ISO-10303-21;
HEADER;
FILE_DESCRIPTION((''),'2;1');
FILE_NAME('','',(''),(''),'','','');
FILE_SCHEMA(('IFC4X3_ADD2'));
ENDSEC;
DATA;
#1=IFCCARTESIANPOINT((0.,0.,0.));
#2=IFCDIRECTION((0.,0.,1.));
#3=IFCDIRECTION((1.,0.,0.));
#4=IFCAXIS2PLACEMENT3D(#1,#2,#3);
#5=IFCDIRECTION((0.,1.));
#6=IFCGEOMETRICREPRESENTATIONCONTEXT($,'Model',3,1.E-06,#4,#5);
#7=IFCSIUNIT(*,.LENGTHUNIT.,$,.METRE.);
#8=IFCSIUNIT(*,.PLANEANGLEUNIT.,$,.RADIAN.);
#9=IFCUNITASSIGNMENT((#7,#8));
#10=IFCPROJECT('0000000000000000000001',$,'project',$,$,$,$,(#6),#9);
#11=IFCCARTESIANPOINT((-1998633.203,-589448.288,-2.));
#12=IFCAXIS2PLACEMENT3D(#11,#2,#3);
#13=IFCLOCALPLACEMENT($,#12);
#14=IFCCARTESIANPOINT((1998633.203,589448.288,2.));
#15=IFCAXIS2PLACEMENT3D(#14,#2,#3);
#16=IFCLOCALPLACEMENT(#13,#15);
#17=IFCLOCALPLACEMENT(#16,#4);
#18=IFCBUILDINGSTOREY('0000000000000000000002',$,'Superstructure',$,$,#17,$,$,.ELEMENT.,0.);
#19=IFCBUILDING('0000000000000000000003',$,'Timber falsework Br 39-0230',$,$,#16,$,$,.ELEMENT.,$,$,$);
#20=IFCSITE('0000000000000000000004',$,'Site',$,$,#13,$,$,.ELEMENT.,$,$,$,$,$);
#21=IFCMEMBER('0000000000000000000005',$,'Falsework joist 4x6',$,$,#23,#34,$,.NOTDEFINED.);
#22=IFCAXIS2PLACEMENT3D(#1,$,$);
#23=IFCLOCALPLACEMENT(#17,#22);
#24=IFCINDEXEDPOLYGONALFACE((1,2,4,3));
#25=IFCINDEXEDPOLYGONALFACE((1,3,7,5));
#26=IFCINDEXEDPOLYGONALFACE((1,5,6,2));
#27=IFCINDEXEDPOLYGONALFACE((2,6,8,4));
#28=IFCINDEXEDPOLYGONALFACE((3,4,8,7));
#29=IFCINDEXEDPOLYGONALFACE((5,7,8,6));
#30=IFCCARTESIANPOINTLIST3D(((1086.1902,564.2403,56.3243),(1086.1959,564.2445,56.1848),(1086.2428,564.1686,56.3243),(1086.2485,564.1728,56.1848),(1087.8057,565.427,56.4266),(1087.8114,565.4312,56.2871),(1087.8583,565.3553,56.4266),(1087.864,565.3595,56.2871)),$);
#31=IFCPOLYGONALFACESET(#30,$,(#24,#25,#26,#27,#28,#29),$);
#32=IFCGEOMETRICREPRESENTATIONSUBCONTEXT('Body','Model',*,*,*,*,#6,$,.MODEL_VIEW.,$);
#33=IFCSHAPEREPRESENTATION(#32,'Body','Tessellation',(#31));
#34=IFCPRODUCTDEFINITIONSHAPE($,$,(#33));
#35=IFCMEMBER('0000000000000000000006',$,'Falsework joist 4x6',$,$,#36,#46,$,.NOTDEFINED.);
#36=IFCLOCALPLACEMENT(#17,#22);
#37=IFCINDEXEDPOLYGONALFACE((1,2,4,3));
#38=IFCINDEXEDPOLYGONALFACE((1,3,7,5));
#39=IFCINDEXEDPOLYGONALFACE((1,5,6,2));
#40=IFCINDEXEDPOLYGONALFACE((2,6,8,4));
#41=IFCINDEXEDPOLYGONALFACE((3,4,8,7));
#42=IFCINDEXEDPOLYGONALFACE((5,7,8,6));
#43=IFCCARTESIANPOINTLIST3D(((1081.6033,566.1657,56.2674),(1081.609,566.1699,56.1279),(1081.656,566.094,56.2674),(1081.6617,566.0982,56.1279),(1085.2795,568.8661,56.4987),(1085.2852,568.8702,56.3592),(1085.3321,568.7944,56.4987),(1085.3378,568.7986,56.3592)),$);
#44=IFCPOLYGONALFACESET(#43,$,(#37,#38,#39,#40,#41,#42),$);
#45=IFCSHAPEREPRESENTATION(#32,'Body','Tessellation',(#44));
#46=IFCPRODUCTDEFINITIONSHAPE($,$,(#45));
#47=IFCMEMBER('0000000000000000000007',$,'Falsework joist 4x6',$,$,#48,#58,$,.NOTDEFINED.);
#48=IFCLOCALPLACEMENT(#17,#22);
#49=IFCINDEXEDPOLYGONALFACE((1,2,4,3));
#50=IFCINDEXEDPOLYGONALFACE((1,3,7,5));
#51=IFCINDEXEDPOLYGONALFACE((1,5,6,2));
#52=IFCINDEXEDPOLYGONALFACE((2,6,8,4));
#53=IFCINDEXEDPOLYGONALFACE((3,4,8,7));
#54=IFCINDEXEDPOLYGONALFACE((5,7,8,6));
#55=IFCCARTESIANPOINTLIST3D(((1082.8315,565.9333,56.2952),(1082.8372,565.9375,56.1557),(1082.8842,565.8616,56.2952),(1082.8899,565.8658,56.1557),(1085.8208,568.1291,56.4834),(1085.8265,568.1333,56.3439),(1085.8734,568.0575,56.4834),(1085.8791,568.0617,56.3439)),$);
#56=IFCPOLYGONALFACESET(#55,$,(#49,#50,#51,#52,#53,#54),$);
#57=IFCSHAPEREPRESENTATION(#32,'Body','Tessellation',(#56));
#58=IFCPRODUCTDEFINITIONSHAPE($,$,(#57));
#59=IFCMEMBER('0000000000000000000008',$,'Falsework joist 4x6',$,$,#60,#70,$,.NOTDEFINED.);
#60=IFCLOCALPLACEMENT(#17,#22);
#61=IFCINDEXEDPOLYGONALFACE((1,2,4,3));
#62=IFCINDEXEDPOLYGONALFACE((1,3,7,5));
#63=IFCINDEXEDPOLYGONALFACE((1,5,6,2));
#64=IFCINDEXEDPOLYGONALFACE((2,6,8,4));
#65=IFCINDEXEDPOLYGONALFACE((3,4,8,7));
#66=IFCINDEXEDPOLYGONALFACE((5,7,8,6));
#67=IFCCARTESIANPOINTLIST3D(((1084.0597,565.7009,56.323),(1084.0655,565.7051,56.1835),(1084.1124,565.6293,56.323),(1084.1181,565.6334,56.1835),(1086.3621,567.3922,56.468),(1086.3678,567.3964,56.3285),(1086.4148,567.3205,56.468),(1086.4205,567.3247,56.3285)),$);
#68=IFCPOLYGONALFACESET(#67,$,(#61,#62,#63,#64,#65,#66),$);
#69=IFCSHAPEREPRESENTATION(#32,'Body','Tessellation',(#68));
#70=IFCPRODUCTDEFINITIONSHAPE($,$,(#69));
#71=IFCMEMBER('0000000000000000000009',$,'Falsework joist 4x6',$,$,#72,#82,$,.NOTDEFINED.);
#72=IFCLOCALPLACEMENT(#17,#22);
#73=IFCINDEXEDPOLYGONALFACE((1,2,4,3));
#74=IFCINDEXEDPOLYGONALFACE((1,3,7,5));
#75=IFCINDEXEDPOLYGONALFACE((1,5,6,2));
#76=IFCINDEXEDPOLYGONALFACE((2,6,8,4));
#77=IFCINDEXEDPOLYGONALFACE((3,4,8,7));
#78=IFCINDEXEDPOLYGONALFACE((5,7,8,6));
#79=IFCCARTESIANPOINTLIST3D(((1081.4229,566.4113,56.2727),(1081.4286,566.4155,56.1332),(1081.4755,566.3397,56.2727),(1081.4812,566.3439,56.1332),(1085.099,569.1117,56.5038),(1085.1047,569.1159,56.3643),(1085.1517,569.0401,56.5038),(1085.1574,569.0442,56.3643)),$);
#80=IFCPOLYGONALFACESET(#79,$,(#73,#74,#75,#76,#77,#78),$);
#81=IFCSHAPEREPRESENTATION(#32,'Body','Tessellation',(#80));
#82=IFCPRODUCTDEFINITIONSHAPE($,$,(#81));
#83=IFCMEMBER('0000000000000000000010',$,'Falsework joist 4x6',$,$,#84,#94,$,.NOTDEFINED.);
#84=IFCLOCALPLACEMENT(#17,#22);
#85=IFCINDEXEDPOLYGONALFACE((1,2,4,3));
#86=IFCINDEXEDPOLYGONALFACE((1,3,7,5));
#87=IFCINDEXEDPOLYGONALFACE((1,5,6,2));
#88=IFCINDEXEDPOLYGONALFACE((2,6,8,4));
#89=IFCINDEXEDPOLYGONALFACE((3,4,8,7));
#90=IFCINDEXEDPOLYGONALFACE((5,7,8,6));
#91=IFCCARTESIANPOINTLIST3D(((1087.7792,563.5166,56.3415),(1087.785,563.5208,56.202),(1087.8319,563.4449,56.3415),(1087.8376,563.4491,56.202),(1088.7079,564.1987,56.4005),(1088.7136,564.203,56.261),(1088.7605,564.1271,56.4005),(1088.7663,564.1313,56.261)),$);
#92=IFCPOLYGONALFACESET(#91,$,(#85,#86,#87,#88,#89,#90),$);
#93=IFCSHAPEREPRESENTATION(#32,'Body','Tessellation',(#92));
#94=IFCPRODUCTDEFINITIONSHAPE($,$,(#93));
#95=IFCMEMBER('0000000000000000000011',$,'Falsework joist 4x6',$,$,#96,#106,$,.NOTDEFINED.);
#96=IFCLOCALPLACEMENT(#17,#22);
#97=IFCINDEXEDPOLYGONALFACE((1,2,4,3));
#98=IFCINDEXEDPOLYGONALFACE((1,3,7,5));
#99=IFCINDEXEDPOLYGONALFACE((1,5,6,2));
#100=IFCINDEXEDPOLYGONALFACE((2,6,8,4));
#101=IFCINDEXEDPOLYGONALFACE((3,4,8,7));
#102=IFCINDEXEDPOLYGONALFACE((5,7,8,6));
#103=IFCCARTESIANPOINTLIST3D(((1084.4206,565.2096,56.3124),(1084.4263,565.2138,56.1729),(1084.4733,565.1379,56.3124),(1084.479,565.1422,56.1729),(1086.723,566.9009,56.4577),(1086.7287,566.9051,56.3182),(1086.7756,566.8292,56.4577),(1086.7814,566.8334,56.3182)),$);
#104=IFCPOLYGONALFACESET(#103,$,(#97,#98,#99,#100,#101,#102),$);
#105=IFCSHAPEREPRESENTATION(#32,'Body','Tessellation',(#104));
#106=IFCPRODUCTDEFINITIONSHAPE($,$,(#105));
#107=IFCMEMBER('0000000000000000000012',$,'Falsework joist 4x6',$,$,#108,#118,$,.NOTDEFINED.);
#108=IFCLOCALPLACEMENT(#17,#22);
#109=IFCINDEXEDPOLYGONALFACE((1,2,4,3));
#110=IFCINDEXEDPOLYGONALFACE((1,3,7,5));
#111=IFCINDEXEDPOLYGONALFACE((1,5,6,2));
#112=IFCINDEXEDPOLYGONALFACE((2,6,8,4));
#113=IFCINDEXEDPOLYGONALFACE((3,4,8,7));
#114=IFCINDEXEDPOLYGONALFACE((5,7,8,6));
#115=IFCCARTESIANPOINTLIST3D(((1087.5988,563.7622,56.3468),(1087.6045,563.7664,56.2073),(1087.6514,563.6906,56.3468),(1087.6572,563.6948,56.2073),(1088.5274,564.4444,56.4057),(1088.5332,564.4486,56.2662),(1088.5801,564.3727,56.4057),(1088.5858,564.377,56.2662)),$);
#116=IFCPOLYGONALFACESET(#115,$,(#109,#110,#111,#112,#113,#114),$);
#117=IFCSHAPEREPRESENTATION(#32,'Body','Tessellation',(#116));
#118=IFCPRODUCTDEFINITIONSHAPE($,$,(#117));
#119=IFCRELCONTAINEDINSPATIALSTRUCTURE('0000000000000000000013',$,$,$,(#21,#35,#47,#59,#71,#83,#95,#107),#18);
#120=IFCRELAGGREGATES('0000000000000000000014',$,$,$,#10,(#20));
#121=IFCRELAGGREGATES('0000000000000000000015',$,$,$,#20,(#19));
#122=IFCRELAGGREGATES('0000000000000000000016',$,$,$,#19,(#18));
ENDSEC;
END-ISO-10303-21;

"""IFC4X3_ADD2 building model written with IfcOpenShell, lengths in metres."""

from ifc_helpers import new_model, si_unit, direction, frame, frame_2d, origin, origin_with_axes, place, context, subcontext, project, spatial, rectangle, extrude, element, save


model = new_model("IFC4X3_ADD2")

# Units and contexts
model_context = context("Model", 3, precision=1e-06, world=origin_with_axes(), true_north=direction((0.0, 1.0)))
body_context = subcontext(model_context, "Body", "Model", "MODEL_VIEW")
ifc_project = project(units=[si_unit("LENGTHUNIT", "METRE"), si_unit("PLANEANGLEUNIT", "RADIAN")], contexts=[model_context])

# Site, building, storey
site_placement = place(None, frame((-1998633.203, -589448.288, -2.0), z_axis=(0.0, 0.0, 1.0), x_axis=(1.0, 0.0, 0.0)))
site = spatial("IfcSite", under=ifc_project, at=site_placement, Name="Site", CompositionType="ELEMENT")
building_placement = place(site_placement, frame((1998633.203, 589448.288, 2.0), z_axis=(0.0, 0.0, 1.0), x_axis=(1.0, 0.0, 0.0)))
building = spatial("IfcBuilding", under=site, at=building_placement, Name="Timber falsework Br 39-0230", CompositionType="ELEMENT")
storey_placement = place(building_placement, origin_with_axes())
storey = spatial("IfcBuildingStorey", under=building, at=storey_placement, Name="Superstructure", CompositionType="ELEMENT", Elevation=0.0)

# Members
member_1_placement = place(storey_placement, frame((1086.2222, 564.2087, 56.1848), z_axis=(0.80488, 0.591243, 0.050987), x_axis=(-0.592013, 0.805928, 0.0)))
element("IfcMember", 1, at=member_1_placement, inside=storey, Name="Falsework joist 4x6", PredefinedType="NOTDEFINED", context=body_context, shape_type="SweptSolid", body=[
    extrude(rectangle(XDim=0.0889, YDim=0.1397, at=frame_2d((0.0, 0.0698))), origin(), (0.0, 0.0, 1.0), 2.0072),
])
member_2_placement = place(storey_placement, frame((1081.6354, 566.134, 56.1279), z_axis=(0.804894, 0.591253, 0.050651), x_axis=(-0.592013, 0.805928, 0.0)))
element("IfcMember", 2, at=member_2_placement, inside=storey, Name="Falsework joist 4x6", PredefinedType="NOTDEFINED", context=body_context, shape_type="SweptSolid", body=[
    extrude(rectangle(XDim=0.0889, YDim=0.1397, at=frame_2d((0.0, 0.0698))), origin(), (0.0, 0.0, 1.0), 4.5672),
])
member_3_placement = place(storey_placement, frame((1082.8636, 565.9017, 56.1557), z_axis=(0.804893, 0.591253, 0.050677), x_axis=(-0.592013, 0.805928, 0.0)))
element("IfcMember", 3, at=member_3_placement, inside=storey, Name="Falsework joist 4x6", PredefinedType="NOTDEFINED", context=body_context, shape_type="SweptSolid", body=[
    extrude(rectangle(XDim=0.0889, YDim=0.1397, at=frame_2d((0.0, 0.0698))), origin(), (0.0, 0.0, 1.0), 3.7139),
])
member_4_placement = place(storey_placement, frame((1084.0918, 565.6693, 56.1835), z_axis=(0.804892, 0.591252, 0.050702), x_axis=(-0.592013, 0.805928, 0.0)))
element("IfcMember", 4, at=member_4_placement, inside=storey, Name="Falsework joist 4x6", PredefinedType="NOTDEFINED", context=body_context, shape_type="SweptSolid", body=[
    extrude(rectangle(XDim=0.0889, YDim=0.1397, at=frame_2d((0.0, 0.0698))), origin(), (0.0, 0.0, 1.0), 2.8605),
])
member_5_placement = place(storey_placement, frame((1081.4549, 566.3797, 56.1332), z_axis=(0.804896, 0.591255, 0.0506), x_axis=(-0.592013, 0.805928, 0.0)))
element("IfcMember", 5, at=member_5_placement, inside=storey, Name="Falsework joist 4x6", PredefinedType="NOTDEFINED", context=body_context, shape_type="SweptSolid", body=[
    extrude(rectangle(XDim=0.0889, YDim=0.1397, at=frame_2d((0.0, 0.0698))), origin(), (0.0, 0.0, 1.0), 4.5672),
])
member_6_placement = place(storey_placement, frame((1087.8113, 563.485, 56.202), z_axis=(0.804875, 0.591239, 0.051116), x_axis=(-0.592013, 0.805928, 0.0)))
element("IfcMember", 6, at=member_6_placement, inside=storey, Name="Falsework joist 4x6", PredefinedType="NOTDEFINED", context=body_context, shape_type="SweptSolid", body=[
    extrude(rectangle(XDim=0.0889, YDim=0.1397, at=frame_2d((0.0, 0.0698))), origin(), (0.0, 0.0, 1.0), 1.1538),
])
member_7_placement = place(storey_placement, frame((1084.4527, 565.178, 56.1729), z_axis=(0.804887, 0.591249, 0.050806), x_axis=(-0.592013, 0.805928, 0.0)))
element("IfcMember", 7, at=member_7_placement, inside=storey, Name="Falsework joist 4x6", PredefinedType="NOTDEFINED", context=body_context, shape_type="SweptSolid", body=[
    extrude(rectangle(XDim=0.0889, YDim=0.1397, at=frame_2d((0.0, 0.0698))), origin(), (0.0, 0.0, 1.0), 2.8605),
])
member_8_placement = place(storey_placement, frame((1087.6309, 563.7306, 56.2073), z_axis=(0.804877, 0.591241, 0.051064), x_axis=(-0.592013, 0.805928, 0.0)))
element("IfcMember", 8, at=member_8_placement, inside=storey, Name="Falsework joist 4x6", PredefinedType="NOTDEFINED", context=body_context, shape_type="SweptSolid", body=[
    extrude(rectangle(XDim=0.0889, YDim=0.1397, at=frame_2d((0.0, 0.0698))), origin(), (0.0, 0.0, 1.0), 1.1538),
])

save(model, "model.ifc")
